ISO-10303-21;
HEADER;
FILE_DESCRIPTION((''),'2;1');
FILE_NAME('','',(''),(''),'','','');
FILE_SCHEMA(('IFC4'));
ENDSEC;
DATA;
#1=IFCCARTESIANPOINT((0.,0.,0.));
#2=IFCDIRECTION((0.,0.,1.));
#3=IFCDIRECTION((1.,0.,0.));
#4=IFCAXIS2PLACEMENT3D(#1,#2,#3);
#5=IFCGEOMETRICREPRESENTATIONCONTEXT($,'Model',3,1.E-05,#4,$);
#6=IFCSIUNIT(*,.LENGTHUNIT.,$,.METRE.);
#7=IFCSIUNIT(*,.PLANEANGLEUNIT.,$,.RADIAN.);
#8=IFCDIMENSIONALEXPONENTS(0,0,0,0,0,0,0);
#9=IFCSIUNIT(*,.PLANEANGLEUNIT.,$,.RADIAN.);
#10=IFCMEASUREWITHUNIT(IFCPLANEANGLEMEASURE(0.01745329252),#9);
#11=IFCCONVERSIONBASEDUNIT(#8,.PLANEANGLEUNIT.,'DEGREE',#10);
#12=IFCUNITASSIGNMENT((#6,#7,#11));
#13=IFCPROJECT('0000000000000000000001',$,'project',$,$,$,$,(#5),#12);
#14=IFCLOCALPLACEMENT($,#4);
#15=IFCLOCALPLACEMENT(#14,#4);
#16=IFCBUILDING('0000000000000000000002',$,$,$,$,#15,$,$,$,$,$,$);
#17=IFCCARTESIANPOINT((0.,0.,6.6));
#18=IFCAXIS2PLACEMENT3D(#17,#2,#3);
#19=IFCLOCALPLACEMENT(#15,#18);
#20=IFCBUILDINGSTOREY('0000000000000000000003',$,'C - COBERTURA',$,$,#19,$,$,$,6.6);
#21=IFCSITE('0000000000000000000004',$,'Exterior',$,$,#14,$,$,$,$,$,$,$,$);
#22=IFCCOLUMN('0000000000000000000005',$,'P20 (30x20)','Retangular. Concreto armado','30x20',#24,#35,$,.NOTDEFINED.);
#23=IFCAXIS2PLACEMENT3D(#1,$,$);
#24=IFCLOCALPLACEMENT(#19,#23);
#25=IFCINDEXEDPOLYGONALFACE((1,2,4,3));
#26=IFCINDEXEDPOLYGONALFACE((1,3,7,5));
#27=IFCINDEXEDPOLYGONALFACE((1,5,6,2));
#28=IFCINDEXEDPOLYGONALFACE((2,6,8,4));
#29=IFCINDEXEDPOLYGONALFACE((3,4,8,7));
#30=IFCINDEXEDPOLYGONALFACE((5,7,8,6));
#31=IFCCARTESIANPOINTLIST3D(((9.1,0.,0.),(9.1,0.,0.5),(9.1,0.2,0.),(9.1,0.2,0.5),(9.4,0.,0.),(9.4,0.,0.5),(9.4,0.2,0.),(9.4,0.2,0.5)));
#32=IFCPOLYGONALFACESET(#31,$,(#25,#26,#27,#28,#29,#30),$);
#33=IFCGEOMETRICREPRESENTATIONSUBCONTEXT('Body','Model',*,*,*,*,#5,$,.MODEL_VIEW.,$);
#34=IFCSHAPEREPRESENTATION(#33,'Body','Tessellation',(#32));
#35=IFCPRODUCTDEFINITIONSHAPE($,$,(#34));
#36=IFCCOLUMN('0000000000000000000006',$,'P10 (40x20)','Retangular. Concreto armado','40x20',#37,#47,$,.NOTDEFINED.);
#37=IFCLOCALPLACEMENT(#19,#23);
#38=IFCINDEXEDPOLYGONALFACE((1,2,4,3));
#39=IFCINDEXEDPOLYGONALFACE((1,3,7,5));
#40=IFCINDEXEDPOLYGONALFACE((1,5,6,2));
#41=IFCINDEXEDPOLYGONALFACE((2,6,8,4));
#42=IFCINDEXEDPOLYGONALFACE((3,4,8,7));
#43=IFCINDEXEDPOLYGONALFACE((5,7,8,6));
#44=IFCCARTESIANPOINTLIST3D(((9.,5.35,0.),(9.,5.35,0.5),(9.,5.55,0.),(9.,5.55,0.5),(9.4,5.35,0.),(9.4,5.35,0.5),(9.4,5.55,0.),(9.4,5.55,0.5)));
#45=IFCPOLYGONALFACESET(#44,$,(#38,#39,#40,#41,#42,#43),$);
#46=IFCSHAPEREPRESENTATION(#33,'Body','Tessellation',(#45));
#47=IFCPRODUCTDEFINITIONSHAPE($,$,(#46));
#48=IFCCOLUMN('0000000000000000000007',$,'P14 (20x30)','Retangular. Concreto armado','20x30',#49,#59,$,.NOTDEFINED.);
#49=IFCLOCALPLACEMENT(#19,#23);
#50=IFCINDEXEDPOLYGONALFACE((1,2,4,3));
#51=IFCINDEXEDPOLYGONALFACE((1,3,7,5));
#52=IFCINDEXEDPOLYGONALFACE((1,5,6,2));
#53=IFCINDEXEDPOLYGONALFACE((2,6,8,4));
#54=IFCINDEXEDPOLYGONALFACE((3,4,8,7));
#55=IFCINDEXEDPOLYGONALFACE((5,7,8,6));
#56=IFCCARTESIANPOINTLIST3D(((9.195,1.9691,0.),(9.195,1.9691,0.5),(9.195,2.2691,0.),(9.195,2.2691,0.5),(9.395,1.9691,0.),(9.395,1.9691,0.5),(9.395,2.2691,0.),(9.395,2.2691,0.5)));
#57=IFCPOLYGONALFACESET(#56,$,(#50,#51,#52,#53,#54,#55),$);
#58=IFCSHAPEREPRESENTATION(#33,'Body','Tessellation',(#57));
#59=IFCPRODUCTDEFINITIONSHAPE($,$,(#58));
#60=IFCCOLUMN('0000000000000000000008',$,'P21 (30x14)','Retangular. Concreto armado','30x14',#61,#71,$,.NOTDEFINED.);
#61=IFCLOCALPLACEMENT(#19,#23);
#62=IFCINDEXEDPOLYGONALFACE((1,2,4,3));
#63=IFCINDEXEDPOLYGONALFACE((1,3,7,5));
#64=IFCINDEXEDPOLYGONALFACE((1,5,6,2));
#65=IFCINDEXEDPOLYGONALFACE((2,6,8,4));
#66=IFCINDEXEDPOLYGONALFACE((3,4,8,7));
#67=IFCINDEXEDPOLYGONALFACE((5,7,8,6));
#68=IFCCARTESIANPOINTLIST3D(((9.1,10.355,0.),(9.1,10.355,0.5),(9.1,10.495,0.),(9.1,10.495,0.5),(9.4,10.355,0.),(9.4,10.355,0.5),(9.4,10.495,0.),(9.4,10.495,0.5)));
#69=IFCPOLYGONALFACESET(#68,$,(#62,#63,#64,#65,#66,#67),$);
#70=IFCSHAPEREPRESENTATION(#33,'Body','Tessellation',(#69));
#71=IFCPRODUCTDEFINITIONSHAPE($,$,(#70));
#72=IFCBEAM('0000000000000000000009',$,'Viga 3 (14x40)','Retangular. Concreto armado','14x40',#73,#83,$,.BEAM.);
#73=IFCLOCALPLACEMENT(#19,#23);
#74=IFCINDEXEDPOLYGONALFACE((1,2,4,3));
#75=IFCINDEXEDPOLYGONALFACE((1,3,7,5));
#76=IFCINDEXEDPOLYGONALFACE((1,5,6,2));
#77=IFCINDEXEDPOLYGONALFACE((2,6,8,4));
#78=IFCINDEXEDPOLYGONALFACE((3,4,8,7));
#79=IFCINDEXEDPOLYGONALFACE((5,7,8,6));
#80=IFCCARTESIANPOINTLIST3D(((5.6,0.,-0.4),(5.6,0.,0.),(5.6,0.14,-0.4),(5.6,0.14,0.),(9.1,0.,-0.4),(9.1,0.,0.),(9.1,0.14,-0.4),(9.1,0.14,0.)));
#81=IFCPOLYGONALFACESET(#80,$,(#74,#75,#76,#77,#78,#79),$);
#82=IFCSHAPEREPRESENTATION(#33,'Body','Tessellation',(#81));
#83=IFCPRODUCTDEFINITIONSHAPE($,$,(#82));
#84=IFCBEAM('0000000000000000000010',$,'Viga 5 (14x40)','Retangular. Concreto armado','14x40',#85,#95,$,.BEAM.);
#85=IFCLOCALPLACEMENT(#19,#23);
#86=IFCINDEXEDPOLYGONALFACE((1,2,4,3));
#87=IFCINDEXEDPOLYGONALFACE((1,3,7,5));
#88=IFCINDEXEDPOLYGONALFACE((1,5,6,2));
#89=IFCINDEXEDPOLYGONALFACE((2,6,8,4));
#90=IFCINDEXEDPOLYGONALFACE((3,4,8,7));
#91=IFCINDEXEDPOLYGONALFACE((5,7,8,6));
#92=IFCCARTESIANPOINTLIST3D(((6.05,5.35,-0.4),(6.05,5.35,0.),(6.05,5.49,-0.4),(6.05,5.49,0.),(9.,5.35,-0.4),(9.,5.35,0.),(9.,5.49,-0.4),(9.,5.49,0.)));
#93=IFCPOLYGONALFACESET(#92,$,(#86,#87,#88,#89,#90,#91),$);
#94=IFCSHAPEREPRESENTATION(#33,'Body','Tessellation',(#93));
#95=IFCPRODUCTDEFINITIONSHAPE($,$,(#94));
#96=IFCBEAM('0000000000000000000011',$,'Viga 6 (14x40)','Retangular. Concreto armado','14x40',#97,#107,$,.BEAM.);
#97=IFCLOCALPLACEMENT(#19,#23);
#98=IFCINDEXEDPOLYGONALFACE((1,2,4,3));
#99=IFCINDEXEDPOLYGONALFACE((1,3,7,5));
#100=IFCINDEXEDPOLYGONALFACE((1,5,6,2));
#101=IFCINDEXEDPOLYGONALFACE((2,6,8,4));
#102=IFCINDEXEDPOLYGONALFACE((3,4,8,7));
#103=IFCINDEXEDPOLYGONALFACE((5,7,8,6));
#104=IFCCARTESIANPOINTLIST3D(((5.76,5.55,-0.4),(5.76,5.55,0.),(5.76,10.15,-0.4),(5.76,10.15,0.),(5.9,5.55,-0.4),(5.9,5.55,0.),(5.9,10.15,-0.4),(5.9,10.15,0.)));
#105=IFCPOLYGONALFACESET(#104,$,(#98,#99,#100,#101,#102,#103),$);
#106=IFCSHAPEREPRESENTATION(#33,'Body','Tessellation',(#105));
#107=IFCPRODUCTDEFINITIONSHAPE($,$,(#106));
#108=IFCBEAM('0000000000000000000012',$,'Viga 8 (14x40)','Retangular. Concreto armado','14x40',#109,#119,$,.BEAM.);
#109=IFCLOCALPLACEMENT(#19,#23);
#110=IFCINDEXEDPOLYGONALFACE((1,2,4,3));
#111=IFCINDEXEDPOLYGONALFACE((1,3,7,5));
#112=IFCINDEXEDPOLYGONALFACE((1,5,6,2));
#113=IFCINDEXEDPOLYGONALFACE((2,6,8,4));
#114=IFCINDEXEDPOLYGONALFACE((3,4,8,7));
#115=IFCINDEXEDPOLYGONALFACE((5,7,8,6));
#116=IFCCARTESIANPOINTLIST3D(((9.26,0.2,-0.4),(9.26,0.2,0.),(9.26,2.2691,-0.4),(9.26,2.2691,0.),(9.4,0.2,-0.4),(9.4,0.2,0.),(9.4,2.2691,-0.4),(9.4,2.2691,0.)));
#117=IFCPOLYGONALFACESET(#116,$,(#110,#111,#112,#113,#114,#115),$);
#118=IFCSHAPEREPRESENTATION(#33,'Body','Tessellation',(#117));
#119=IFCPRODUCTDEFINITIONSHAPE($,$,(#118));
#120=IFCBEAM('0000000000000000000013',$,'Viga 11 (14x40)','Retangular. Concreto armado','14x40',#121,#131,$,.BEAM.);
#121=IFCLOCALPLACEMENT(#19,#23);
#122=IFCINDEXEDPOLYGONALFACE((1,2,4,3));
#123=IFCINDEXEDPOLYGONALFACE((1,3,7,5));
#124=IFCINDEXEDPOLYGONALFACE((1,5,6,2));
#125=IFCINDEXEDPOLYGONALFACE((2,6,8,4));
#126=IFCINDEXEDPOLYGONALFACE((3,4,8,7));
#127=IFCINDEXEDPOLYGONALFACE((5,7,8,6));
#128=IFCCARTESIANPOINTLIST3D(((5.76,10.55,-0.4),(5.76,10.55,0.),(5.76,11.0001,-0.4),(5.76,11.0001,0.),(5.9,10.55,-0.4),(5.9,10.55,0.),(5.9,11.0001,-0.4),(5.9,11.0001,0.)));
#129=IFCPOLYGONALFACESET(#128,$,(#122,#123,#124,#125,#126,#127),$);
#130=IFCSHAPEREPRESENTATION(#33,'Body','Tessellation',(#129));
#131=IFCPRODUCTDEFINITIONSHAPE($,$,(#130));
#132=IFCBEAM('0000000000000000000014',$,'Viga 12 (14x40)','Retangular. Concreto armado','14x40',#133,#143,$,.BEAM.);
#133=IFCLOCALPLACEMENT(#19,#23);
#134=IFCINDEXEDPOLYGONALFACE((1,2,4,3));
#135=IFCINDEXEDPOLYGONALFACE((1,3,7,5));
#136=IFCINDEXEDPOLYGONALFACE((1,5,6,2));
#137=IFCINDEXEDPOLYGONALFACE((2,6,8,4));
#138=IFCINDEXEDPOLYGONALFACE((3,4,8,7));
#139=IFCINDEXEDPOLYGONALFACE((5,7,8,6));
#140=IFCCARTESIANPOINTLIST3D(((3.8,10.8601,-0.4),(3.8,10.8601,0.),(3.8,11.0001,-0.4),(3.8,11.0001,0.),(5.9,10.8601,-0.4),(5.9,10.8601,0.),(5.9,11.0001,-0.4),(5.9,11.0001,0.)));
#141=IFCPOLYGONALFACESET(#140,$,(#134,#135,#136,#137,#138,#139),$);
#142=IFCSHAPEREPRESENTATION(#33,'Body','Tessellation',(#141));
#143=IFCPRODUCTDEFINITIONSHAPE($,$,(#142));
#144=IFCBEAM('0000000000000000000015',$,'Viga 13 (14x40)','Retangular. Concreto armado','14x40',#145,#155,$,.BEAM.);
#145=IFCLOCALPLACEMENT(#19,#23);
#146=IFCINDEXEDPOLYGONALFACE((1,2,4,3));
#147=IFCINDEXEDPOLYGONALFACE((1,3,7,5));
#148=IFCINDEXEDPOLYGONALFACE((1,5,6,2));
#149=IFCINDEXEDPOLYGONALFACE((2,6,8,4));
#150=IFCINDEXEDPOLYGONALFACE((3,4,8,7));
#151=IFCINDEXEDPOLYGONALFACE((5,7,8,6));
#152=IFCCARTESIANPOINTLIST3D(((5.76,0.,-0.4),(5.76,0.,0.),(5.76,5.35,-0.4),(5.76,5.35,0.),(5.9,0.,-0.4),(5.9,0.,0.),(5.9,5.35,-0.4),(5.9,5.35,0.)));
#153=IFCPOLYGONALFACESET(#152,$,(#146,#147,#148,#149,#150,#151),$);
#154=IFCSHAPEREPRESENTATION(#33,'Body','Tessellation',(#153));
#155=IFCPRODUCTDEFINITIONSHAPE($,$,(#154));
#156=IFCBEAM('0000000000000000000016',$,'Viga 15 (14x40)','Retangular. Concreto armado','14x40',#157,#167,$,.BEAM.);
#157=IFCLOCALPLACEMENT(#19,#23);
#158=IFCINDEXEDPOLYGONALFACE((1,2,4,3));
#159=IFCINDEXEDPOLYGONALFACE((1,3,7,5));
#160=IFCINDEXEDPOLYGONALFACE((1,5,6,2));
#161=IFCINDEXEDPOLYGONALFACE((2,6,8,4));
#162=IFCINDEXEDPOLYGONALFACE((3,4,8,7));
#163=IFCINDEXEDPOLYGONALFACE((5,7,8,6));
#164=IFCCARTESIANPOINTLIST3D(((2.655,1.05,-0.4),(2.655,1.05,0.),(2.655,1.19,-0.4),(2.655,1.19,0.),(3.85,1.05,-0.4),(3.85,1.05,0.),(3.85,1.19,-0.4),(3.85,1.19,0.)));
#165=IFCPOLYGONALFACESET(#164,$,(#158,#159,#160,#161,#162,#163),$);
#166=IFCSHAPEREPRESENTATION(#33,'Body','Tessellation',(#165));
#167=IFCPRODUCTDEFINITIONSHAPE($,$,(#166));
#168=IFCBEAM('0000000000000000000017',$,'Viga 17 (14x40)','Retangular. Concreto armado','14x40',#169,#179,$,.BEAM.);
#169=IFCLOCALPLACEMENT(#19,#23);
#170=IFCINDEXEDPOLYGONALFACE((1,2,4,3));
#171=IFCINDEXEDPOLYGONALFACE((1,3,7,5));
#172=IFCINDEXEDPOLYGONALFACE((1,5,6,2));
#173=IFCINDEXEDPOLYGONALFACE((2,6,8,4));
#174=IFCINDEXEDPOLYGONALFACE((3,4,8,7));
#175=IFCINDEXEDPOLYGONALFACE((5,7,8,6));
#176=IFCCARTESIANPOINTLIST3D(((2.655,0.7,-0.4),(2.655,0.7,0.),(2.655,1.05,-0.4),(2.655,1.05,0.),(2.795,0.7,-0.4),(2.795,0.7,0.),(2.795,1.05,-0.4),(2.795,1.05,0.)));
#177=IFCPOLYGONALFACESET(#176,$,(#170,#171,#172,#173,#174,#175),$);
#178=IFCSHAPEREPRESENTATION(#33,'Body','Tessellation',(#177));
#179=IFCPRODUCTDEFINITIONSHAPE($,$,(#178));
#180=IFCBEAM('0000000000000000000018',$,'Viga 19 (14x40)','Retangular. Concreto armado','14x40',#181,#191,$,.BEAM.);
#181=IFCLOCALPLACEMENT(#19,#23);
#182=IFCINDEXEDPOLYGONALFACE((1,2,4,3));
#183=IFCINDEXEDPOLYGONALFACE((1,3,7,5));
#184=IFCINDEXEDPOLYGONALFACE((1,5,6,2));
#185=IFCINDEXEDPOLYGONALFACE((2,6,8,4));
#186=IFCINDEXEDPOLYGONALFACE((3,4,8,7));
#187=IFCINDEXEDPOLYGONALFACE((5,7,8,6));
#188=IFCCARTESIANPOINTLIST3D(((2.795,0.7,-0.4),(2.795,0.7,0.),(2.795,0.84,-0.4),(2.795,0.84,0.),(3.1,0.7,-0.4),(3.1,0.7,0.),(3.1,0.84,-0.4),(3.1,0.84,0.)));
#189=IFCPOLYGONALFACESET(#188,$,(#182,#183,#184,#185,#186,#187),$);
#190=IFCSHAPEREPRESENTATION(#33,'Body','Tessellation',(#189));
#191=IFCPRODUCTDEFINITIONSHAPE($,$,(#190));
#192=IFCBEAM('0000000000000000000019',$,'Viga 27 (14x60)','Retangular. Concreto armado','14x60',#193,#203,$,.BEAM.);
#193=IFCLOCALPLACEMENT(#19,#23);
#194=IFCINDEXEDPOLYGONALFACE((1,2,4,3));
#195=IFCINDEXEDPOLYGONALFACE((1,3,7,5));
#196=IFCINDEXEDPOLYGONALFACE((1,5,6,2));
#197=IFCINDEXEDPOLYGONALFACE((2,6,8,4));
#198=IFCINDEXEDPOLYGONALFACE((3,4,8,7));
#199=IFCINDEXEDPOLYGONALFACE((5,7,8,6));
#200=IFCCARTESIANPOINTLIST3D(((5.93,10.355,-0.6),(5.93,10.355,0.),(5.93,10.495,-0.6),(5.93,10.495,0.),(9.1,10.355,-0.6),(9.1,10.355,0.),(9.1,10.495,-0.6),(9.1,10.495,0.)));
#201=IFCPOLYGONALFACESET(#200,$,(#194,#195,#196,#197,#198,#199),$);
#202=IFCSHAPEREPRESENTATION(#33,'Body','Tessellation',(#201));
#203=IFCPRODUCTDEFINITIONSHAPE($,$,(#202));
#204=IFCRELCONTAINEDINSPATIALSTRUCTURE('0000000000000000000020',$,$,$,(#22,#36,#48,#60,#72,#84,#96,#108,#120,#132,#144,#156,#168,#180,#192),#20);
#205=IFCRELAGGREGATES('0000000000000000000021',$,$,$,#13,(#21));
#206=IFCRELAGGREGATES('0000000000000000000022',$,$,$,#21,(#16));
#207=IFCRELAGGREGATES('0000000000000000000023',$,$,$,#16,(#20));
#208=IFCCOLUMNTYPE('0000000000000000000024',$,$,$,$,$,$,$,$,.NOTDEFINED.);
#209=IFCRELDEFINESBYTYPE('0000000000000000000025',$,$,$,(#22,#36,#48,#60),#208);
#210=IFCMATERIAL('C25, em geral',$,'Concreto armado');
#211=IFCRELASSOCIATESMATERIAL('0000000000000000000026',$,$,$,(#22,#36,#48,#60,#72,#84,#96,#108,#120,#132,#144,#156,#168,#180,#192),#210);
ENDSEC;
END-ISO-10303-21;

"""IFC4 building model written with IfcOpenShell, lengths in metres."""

from ifc_helpers import new_model, entity, si_unit, converted_unit, frame, frame_2d, origin_with_axes, origin_2d_with_axis, place, context, subcontext, project, spatial, rectangle, extrude, material, type_object, element, save


model = new_model("IFC4")

# Units and contexts
model_context = context("Model", 3, precision=1e-05, world=origin_with_axes())
body_context = subcontext(model_context, "Body", "Model", "MODEL_VIEW")
ifc_project = project(units=[si_unit("LENGTHUNIT", "METRE"), si_unit("PLANEANGLEUNIT", "RADIAN"), converted_unit("PLANEANGLEUNIT", "DEGREE", entity("IfcPlaneAngleMeasure", 0.01745329252), si_unit("PLANEANGLEUNIT", "RADIAN"), dimensions=[0, 0, 0, 0, 0, 0, 0])], contexts=[model_context])

# Site, building, storey
site_placement = place(None, origin_with_axes())
site = spatial("IfcSite", under=ifc_project, at=site_placement, Name="Exterior")
building_placement = place(site_placement, origin_with_axes())
building = spatial("IfcBuilding", under=site, at=building_placement)
storey_placement = place(building_placement, frame((0.0, 0.0, 6.6), z_axis=(0.0, 0.0, 1.0), x_axis=(1.0, 0.0, 0.0)))
storey = spatial("IfcBuildingStorey", under=building, at=storey_placement, Name="C - COBERTURA", Elevation=6.6)

# Columns
ifc_material = material(Name="C25, em geral", Category="Concreto armado")
column_type = type_object("IfcColumnType", PredefinedType="NOTDEFINED")
column_1_placement = place(storey_placement, frame((9.25, 0.1, 0.0), z_axis=(0.0, 0.0, 1.0), x_axis=(1.0, 0.0, 0.0)))
element("IfcColumn", 1, at=column_1_placement, inside=storey, type_object=column_type, material=ifc_material, Name="P20 (30x20)", Description="Retangular. Concreto armado", ObjectType="30x20", PredefinedType="NOTDEFINED", context=body_context, shape_type="SweptSolid", body=[
    extrude(rectangle(XDim=0.3, YDim=0.2, at=origin_2d_with_axis()), origin_with_axes(), (0.0, 0.0, 1.0), 0.5),
])
column_2_placement = place(storey_placement, frame((9.2, 5.45, 0.0), z_axis=(0.0, 0.0, 1.0), x_axis=(1.0, 0.0, 0.0)))
element("IfcColumn", 2, at=column_2_placement, inside=storey, type_object=column_type, material=ifc_material, Name="P10 (40x20)", Description="Retangular. Concreto armado", ObjectType="40x20", PredefinedType="NOTDEFINED", context=body_context, shape_type="SweptSolid", body=[
    extrude(rectangle(XDim=0.4, YDim=0.2, at=origin_2d_with_axis()), origin_with_axes(), (0.0, 0.0, 1.0), 0.5),
])
column_3_placement = place(storey_placement, frame((9.295, 2.1191, 0.0), z_axis=(0.0, 0.0, 1.0), x_axis=(1.0, 0.0, 0.0)))
element("IfcColumn", 3, at=column_3_placement, inside=storey, type_object=column_type, material=ifc_material, Name="P14 (20x30)", Description="Retangular. Concreto armado", ObjectType="20x30", PredefinedType="NOTDEFINED", context=body_context, shape_type="SweptSolid", body=[
    extrude(rectangle(XDim=0.2, YDim=0.3, at=origin_2d_with_axis()), origin_with_axes(), (0.0, 0.0, 1.0), 0.5),
])
column_4_placement = place(storey_placement, frame((9.25, 10.425, 0.0), z_axis=(0.0, 0.0, 1.0), x_axis=(1.0, 0.0, 0.0)))
element("IfcColumn", 4, at=column_4_placement, inside=storey, type_object=column_type, material=ifc_material, Name="P21 (30x14)", Description="Retangular. Concreto armado", ObjectType="30x14", PredefinedType="NOTDEFINED", context=body_context, shape_type="SweptSolid", body=[
    extrude(rectangle(XDim=0.3, YDim=0.14, at=origin_2d_with_axis()), origin_with_axes(), (0.0, 0.0, 1.0), 0.5),
])

# Beams
beam_1_placement = place(storey_placement, frame((9.1, 0.07, 0.0), z_axis=(-1.0, 0.0, 0.0), x_axis=(0.0, -1.0, 0.0)))
element("IfcBeam", 5, at=beam_1_placement, inside=storey, material=ifc_material, Name="Viga 3 (14x40)", Description="Retangular. Concreto armado", ObjectType="14x40", PredefinedType="BEAM", context=body_context, shape_type="SweptSolid", body=[
    extrude(rectangle(XDim=0.14, YDim=0.4, at=frame_2d((0.0, -0.2), x_axis=(1.0, 0.0))), origin_with_axes(), (0.0, 0.0, 1.0), 3.5),
])
beam_2_placement = place(storey_placement, frame((9.0, 5.42, 0.0), z_axis=(-1.0, 0.0, 0.0), x_axis=(0.0, -1.0, 0.0)))
element("IfcBeam", 6, at=beam_2_placement, inside=storey, material=ifc_material, Name="Viga 5 (14x40)", Description="Retangular. Concreto armado", ObjectType="14x40", PredefinedType="BEAM", context=body_context, shape_type="SweptSolid", body=[
    extrude(rectangle(XDim=0.14, YDim=0.4, at=frame_2d((0.0, -0.2), x_axis=(1.0, 0.0))), origin_with_axes(), (0.0, 0.0, 1.0), 2.95),
])
beam_3_placement = place(storey_placement, frame((5.83, 10.15, 0.0), z_axis=(0.0, -1.0, 0.0), x_axis=(1.0, 0.0, 0.0)))
element("IfcBeam", 7, at=beam_3_placement, inside=storey, material=ifc_material, Name="Viga 6 (14x40)", Description="Retangular. Concreto armado", ObjectType="14x40", PredefinedType="BEAM", context=body_context, shape_type="SweptSolid", body=[
    extrude(rectangle(XDim=0.14, YDim=0.4, at=frame_2d((0.0, -0.2), x_axis=(1.0, 0.0))), origin_with_axes(), (0.0, 0.0, 1.0), 4.6),
])
beam_4_placement = place(storey_placement, frame((9.33, 2.2691, 0.0), z_axis=(0.0, -1.0, 0.0), x_axis=(1.0, 0.0, 0.0)))
element("IfcBeam", 8, at=beam_4_placement, inside=storey, material=ifc_material, Name="Viga 8 (14x40)", Description="Retangular. Concreto armado", ObjectType="14x40", PredefinedType="BEAM", context=body_context, shape_type="SweptSolid", body=[
    extrude(rectangle(XDim=0.14, YDim=0.4, at=frame_2d((0.0, -0.2), x_axis=(1.0, 0.0))), origin_with_axes(), (0.0, 0.0, 1.0), 2.0691),
])
beam_5_placement = place(storey_placement, frame((5.83, 10.55, 0.0), z_axis=(0.0, 1.0, 0.0), x_axis=(-1.0, 0.0, 0.0)))
element("IfcBeam", 9, at=beam_5_placement, inside=storey, material=ifc_material, Name="Viga 11 (14x40)", Description="Retangular. Concreto armado", ObjectType="14x40", PredefinedType="BEAM", context=body_context, shape_type="SweptSolid", body=[
    extrude(rectangle(XDim=0.14, YDim=0.4, at=frame_2d((0.0, -0.2), x_axis=(1.0, 0.0))), origin_with_axes(), (0.0, 0.0, 1.0), 0.4501),
])
beam_6_placement = place(storey_placement, frame((3.8, 10.9301, 0.0), z_axis=(1.0, 0.0, 0.0), x_axis=(0.0, 1.0, 0.0)))
element("IfcBeam", 10, at=beam_6_placement, inside=storey, material=ifc_material, Name="Viga 12 (14x40)", Description="Retangular. Concreto armado", ObjectType="14x40", PredefinedType="BEAM", context=body_context, shape_type="SweptSolid", body=[
    extrude(rectangle(XDim=0.14, YDim=0.4, at=frame_2d((0.0, -0.2), x_axis=(1.0, 0.0))), origin_with_axes(), (0.0, 0.0, 1.0), 2.1),
])
beam_7_placement = place(storey_placement, frame((5.83, 0.0, 0.0), z_axis=(0.0, 1.0, 0.0), x_axis=(-1.0, 0.0, 0.0)))
element("IfcBeam", 11, at=beam_7_placement, inside=storey, material=ifc_material, Name="Viga 13 (14x40)", Description="Retangular. Concreto armado", ObjectType="14x40", PredefinedType="BEAM", context=body_context, shape_type="SweptSolid", body=[
    extrude(rectangle(XDim=0.14, YDim=0.4, at=frame_2d((0.0, -0.2), x_axis=(1.0, 0.0))), origin_with_axes(), (0.0, 0.0, 1.0), 5.35),
])
beam_8_placement = place(storey_placement, frame((3.85, 1.12, 0.0), z_axis=(-1.0, 0.0, 0.0), x_axis=(0.0, -1.0, 0.0)))
element("IfcBeam", 12, at=beam_8_placement, inside=storey, material=ifc_material, Name="Viga 15 (14x40)", Description="Retangular. Concreto armado", ObjectType="14x40", PredefinedType="BEAM", context=body_context, shape_type="SweptSolid", body=[
    extrude(rectangle(XDim=0.14, YDim=0.4, at=frame_2d((0.0, -0.2), x_axis=(1.0, 0.0))), origin_with_axes(), (0.0, 0.0, 1.0), 1.195),
])
beam_9_placement = place(storey_placement, frame((2.725, 1.05, 0.0), z_axis=(0.0, -1.0, 0.0), x_axis=(1.0, 0.0, 0.0)))
element("IfcBeam", 13, at=beam_9_placement, inside=storey, material=ifc_material, Name="Viga 17 (14x40)", Description="Retangular. Concreto armado", ObjectType="14x40", PredefinedType="BEAM", context=body_context, shape_type="SweptSolid", body=[
    extrude(rectangle(XDim=0.14, YDim=0.4, at=frame_2d((0.0, -0.2), x_axis=(1.0, 0.0))), origin_with_axes(), (0.0, 0.0, 1.0), 0.35),
])
beam_10_placement = place(storey_placement, frame((3.1, 0.77, 0.0), z_axis=(-1.0, 0.0, 0.0), x_axis=(0.0, -1.0, 0.0)))
element("IfcBeam", 14, at=beam_10_placement, inside=storey, material=ifc_material, Name="Viga 19 (14x40)", Description="Retangular. Concreto armado", ObjectType="14x40", PredefinedType="BEAM", context=body_context, shape_type="SweptSolid", body=[
    extrude(rectangle(XDim=0.14, YDim=0.4, at=frame_2d((0.0, -0.2), x_axis=(1.0, 0.0))), origin_with_axes(), (0.0, 0.0, 1.0), 0.305),
])
beam_11_placement = place(storey_placement, frame((5.93, 10.425, 0.0), z_axis=(1.0, 0.0, 0.0), x_axis=(0.0, 1.0, 0.0)))
element("IfcBeam", 15, at=beam_11_placement, inside=storey, material=ifc_material, Name="Viga 27 (14x60)", Description="Retangular. Concreto armado", ObjectType="14x60", PredefinedType="BEAM", context=body_context, shape_type="SweptSolid", body=[
    extrude(rectangle(XDim=0.14, YDim=0.6, at=frame_2d((0.0, -0.3), x_axis=(1.0, 0.0))), origin_with_axes(), (0.0, 0.0, 1.0), 3.17),
])

save(model, "model.ifc")
